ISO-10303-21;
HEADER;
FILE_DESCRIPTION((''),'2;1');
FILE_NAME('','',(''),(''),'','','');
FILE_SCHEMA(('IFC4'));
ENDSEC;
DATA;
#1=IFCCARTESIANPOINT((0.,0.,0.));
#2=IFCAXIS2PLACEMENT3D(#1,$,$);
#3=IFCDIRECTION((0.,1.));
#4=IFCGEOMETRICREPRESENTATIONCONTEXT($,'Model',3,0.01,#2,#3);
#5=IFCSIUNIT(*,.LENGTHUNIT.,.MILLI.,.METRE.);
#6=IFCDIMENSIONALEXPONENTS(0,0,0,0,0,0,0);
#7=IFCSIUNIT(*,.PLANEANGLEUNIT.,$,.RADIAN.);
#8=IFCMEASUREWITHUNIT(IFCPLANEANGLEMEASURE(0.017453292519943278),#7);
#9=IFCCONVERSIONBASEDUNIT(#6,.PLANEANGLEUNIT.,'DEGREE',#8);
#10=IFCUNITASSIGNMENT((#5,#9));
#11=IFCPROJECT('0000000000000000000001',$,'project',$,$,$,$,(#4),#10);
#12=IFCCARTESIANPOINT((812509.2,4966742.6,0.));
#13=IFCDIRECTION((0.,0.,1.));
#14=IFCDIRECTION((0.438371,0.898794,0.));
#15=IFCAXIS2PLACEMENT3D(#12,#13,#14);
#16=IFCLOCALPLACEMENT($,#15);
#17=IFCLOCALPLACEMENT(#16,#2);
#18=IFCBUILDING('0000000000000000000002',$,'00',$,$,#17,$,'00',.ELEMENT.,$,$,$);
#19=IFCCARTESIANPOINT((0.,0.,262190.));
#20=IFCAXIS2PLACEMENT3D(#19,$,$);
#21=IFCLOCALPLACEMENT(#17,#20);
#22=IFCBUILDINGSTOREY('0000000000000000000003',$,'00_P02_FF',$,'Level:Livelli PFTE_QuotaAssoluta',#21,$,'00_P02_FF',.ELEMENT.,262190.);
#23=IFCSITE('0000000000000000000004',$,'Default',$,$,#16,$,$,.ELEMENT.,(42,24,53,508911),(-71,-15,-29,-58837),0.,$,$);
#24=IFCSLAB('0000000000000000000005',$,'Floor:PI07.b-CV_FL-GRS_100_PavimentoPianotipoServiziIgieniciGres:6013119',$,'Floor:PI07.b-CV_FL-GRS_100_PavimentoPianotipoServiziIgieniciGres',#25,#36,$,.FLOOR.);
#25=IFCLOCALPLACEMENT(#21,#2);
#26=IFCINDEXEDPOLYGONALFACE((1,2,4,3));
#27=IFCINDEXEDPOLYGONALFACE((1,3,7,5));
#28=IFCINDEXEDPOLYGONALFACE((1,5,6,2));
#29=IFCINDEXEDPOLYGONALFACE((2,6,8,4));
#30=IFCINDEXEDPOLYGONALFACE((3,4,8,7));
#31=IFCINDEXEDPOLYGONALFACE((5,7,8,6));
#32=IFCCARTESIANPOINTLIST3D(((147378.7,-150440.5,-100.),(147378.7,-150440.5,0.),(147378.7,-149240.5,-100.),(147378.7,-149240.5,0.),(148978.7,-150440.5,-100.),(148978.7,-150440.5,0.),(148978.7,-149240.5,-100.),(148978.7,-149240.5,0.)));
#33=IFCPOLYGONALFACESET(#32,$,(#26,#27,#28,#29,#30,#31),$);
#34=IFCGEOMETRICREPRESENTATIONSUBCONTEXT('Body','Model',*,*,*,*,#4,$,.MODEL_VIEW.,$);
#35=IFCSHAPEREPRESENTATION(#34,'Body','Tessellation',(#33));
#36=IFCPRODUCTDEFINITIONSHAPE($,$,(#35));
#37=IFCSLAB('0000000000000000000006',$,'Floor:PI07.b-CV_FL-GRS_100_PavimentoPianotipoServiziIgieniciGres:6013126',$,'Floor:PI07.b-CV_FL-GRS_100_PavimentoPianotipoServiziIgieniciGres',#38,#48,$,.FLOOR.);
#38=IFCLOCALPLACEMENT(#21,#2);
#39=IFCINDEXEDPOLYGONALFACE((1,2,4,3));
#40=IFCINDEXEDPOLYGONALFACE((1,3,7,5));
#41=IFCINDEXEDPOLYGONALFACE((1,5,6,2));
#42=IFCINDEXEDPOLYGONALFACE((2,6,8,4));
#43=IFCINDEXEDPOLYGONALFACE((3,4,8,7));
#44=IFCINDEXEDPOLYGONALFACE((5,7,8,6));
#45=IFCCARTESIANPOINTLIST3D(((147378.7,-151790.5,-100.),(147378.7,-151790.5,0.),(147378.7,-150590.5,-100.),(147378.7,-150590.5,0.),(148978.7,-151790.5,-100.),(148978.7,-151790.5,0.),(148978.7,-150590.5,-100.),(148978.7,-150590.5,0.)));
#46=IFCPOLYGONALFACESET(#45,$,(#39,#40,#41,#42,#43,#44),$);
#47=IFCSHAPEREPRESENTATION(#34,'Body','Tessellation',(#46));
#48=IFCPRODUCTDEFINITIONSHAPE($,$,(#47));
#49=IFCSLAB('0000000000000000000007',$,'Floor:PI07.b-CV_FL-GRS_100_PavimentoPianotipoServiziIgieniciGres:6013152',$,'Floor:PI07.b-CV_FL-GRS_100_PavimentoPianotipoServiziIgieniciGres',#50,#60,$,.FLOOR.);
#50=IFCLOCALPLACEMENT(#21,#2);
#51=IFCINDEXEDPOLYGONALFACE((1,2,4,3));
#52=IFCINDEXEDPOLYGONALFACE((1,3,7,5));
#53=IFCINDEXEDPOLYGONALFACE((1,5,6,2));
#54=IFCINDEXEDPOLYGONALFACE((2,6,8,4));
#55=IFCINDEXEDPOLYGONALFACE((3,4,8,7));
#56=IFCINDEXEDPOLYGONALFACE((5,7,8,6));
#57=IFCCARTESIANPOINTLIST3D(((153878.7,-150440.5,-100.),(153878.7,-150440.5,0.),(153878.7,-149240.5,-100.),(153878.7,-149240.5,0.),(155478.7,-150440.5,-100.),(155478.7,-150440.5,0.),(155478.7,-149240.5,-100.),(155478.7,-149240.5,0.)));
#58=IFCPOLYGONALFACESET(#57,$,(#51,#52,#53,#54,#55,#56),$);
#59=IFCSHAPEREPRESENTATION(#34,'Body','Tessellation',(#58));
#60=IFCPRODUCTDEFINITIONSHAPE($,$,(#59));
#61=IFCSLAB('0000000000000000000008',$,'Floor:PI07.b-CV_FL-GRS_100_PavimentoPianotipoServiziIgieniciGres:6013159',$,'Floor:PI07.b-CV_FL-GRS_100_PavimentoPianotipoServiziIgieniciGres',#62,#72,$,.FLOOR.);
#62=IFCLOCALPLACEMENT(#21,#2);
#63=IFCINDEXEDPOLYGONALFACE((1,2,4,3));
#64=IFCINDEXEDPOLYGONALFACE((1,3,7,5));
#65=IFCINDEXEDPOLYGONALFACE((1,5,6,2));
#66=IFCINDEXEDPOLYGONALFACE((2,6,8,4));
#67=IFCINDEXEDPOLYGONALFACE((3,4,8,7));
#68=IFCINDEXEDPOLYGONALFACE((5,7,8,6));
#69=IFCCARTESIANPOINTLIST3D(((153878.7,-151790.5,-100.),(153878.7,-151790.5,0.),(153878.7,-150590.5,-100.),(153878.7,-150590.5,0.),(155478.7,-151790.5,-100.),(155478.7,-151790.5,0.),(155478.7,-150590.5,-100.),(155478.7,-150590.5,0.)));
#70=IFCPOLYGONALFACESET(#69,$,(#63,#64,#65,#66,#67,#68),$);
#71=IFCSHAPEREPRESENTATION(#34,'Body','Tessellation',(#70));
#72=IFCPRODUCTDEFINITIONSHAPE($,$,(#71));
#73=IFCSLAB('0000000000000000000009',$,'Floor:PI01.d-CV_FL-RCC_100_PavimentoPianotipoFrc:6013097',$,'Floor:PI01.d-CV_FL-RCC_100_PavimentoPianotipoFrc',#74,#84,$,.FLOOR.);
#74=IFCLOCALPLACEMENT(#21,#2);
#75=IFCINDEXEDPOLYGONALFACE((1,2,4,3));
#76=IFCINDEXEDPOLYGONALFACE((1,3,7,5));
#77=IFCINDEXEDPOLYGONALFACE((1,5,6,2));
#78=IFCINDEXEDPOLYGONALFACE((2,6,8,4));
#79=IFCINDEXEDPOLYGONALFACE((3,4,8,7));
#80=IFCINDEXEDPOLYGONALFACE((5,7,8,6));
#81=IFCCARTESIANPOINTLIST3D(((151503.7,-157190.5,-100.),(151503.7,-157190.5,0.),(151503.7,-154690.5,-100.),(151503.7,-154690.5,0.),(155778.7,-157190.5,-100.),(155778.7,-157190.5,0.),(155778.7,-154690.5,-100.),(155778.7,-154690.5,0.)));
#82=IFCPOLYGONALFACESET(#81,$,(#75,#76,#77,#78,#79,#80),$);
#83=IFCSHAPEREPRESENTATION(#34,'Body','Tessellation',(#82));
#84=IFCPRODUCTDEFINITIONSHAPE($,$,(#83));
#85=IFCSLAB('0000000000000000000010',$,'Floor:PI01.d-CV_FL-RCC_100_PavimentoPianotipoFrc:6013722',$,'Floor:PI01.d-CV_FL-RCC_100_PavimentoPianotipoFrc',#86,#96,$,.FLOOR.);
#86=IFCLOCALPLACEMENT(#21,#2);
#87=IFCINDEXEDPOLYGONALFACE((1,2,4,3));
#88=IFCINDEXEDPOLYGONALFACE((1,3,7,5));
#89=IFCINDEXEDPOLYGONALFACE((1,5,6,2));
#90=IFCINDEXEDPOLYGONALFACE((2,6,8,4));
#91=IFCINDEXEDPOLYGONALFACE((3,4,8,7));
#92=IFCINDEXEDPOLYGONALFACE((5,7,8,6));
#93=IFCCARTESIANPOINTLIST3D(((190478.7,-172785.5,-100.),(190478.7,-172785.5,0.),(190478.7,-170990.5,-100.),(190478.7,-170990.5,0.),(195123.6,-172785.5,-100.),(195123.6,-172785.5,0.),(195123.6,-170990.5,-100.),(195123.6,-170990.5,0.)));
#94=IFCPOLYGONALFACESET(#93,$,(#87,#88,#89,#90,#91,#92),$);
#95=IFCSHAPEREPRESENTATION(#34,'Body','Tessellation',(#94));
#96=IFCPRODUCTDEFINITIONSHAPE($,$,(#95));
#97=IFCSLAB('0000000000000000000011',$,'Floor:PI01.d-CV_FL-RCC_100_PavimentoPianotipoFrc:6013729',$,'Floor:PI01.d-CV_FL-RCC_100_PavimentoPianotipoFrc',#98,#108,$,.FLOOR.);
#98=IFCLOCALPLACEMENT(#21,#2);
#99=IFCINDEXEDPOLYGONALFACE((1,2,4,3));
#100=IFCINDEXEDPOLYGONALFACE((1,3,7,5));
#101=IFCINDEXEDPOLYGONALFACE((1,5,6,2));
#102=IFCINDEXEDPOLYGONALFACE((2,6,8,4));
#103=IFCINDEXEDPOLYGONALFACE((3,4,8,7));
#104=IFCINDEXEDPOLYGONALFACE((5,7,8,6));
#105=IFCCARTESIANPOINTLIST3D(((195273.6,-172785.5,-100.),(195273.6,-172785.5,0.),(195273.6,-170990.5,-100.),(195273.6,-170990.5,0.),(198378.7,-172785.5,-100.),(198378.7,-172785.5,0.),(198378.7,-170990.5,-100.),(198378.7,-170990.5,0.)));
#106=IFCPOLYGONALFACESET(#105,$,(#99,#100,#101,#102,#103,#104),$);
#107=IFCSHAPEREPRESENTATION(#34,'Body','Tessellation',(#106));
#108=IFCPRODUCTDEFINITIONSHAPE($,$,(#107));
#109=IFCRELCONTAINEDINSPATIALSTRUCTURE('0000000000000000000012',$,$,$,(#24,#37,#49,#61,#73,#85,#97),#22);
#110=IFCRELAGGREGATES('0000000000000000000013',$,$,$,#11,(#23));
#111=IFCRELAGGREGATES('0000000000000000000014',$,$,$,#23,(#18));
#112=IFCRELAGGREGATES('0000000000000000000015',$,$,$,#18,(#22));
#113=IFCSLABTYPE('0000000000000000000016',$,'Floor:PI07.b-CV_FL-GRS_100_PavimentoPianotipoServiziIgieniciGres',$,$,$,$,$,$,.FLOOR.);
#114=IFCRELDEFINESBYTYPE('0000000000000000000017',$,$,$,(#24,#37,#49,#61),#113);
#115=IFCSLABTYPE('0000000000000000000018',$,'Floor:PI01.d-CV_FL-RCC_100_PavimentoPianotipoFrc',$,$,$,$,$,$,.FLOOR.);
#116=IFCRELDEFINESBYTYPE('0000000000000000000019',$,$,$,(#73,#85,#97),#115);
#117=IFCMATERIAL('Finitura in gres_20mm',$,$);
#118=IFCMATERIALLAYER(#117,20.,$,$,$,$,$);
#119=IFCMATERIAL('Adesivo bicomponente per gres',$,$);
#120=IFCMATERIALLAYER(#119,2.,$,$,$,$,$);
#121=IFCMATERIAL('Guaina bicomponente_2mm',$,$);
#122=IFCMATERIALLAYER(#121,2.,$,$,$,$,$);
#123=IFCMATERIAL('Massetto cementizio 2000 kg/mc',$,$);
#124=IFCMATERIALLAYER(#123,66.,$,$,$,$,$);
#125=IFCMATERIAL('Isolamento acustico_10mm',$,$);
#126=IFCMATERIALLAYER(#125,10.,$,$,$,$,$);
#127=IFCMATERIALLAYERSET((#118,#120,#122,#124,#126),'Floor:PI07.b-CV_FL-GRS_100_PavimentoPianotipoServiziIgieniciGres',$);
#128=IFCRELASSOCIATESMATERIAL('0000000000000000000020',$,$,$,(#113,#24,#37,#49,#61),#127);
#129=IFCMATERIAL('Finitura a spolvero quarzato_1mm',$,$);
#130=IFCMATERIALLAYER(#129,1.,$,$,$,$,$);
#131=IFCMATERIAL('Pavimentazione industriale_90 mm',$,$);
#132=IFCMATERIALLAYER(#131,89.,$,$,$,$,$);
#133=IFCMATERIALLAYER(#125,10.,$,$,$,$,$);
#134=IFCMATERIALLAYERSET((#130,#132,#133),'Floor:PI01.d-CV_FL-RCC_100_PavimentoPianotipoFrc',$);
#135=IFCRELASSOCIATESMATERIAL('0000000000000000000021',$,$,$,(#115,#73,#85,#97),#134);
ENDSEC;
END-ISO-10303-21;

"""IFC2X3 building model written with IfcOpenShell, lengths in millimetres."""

from ifc_helpers import new_model, entity, si_unit, converted_unit, direction, frame, frame_2d, origin, place, context, subcontext, project, spatial, rectangle, extrude, material, layer, layer_set, layer_usage, type_object, element, save


model = new_model("IFC2X3")

# Units and contexts
model_context = context("Model", 3, precision=0.01, world=origin(), true_north=direction((0.0, 1.0)))
body_context = subcontext(model_context, "Body", "Model", "MODEL_VIEW")
ifc_project = project(units=[si_unit("LENGTHUNIT", "METRE", prefix="MILLI"), converted_unit("PLANEANGLEUNIT", "DEGREE", entity("IfcPlaneAngleMeasure", 0.017453292519943278), si_unit("PLANEANGLEUNIT", "RADIAN"), dimensions=[0, 0, 0, 0, 0, 0, 0])], contexts=[model_context])

# Site, building, storey
site_placement = place(None, frame((812509.2, 4966742.6, 0.0), z_axis=(0.0, 0.0, 1.0), x_axis=(0.438371, 0.898794, 0.0)))
site = spatial("IfcSite", under=ifc_project, at=site_placement, Name="Default", CompositionType="ELEMENT", RefLatitude=(42, 24, 53, 508911), RefLongitude=(-71, -15, -29, -58837), RefElevation=0.0)
building_placement = place(site_placement, origin())
building = spatial("IfcBuilding", under=site, at=building_placement, Name="00", LongName="00", CompositionType="ELEMENT")
storey_placement = place(building_placement, frame((0.0, 0.0, 262190.0)))
storey = spatial("IfcBuildingStorey", under=building, at=storey_placement, Name="00_P02_FF", ObjectType="Level:Livelli PFTE_QuotaAssoluta", LongName="00_P02_FF", CompositionType="ELEMENT", Elevation=262190.0)

# Slabs
ifc_material_1 = material(Name="Massetto cementizio 2000 kg/mc")
ifc_material_2 = material(Name="Isolamento acustico_10mm")
ifc_material_3 = material(Name="Finitura in gres_20mm")
ifc_layer_1 = layer(ifc_material_3, 20.0)
ifc_material_4 = material(Name="Adesivo bicomponente per gres")
ifc_layer_2 = layer(ifc_material_4, 2.0)
ifc_material_5 = material(Name="Guaina bicomponente_2mm")
ifc_layer_3 = layer(ifc_material_5, 2.0)
ifc_layer_4 = layer(ifc_material_1, 66.0)
ifc_layer_5 = layer(ifc_material_2, 10.0)
ifc_layer_set_1 = layer_set([ifc_layer_1, ifc_layer_2, ifc_layer_3, ifc_layer_4, ifc_layer_5], Name="Floor:PI07.b-CV_FL-GRS_100_PavimentoPianotipoServiziIgieniciGres")
ifc_layer_usage_1 = layer_usage(ifc_layer_set_1, "AXIS3", "POSITIVE", 0.0)
slab_type_1 = type_object("IfcSlabType", Name="Floor:PI07.b-CV_FL-GRS_100_PavimentoPianotipoServiziIgieniciGres", PredefinedType="FLOOR", material=ifc_layer_set_1)
slab_1_placement = place(storey_placement, origin())
element("IfcSlab", 1, at=slab_1_placement, inside=storey, type_object=slab_type_1, material=ifc_layer_usage_1, Name="Floor:PI07.b-CV_FL-GRS_100_PavimentoPianotipoServiziIgieniciGres:6013119", ObjectType="Floor:PI07.b-CV_FL-GRS_100_PavimentoPianotipoServiziIgieniciGres", PredefinedType="FLOOR", context=body_context, shape_type="SweptSolid", body=[
    extrude(rectangle(XDim=1200.0, YDim=1600.0, at=frame_2d((0.0, 0.0), x_axis=(1.0, 0.0))), frame((148178.7, -149840.5, 0.0), z_axis=(0.0, 0.0, -1.0), x_axis=(0.0, 1.0, 0.0)), (0.0, 0.0, 1.0), 100.0),
])
ifc_layer_usage_2 = layer_usage(ifc_layer_set_1, "AXIS3", "POSITIVE", 0.0)
slab_2_placement = place(storey_placement, origin())
element("IfcSlab", 2, at=slab_2_placement, inside=storey, type_object=slab_type_1, material=ifc_layer_usage_2, Name="Floor:PI07.b-CV_FL-GRS_100_PavimentoPianotipoServiziIgieniciGres:6013126", ObjectType="Floor:PI07.b-CV_FL-GRS_100_PavimentoPianotipoServiziIgieniciGres", PredefinedType="FLOOR", context=body_context, shape_type="SweptSolid", body=[
    extrude(rectangle(XDim=1200.0, YDim=1600.0, at=frame_2d((0.0, 0.0), x_axis=(1.0, 0.0))), frame((148178.7, -151190.5, 0.0), z_axis=(0.0, 0.0, -1.0), x_axis=(0.0, 1.0, 0.0)), (0.0, 0.0, 1.0), 100.0),
])
ifc_layer_usage_3 = layer_usage(ifc_layer_set_1, "AXIS3", "POSITIVE", 0.0)
slab_3_placement = place(storey_placement, origin())
element("IfcSlab", 3, at=slab_3_placement, inside=storey, type_object=slab_type_1, material=ifc_layer_usage_3, Name="Floor:PI07.b-CV_FL-GRS_100_PavimentoPianotipoServiziIgieniciGres:6013152", ObjectType="Floor:PI07.b-CV_FL-GRS_100_PavimentoPianotipoServiziIgieniciGres", PredefinedType="FLOOR", context=body_context, shape_type="SweptSolid", body=[
    extrude(rectangle(XDim=1200.0, YDim=1600.0, at=frame_2d((0.0, 0.0), x_axis=(1.0, 0.0))), frame((154678.7, -149840.5, 0.0), z_axis=(0.0, 0.0, -1.0), x_axis=(0.0, 1.0, 0.0)), (0.0, 0.0, 1.0), 100.0),
])
ifc_layer_usage_4 = layer_usage(ifc_layer_set_1, "AXIS3", "POSITIVE", 0.0)
slab_4_placement = place(storey_placement, origin())
element("IfcSlab", 4, at=slab_4_placement, inside=storey, type_object=slab_type_1, material=ifc_layer_usage_4, Name="Floor:PI07.b-CV_FL-GRS_100_PavimentoPianotipoServiziIgieniciGres:6013159", ObjectType="Floor:PI07.b-CV_FL-GRS_100_PavimentoPianotipoServiziIgieniciGres", PredefinedType="FLOOR", context=body_context, shape_type="SweptSolid", body=[
    extrude(rectangle(XDim=1200.0, YDim=1600.0, at=frame_2d((0.0, 0.0), x_axis=(1.0, 0.0))), frame((154678.7, -151190.5, 0.0), z_axis=(0.0, 0.0, -1.0), x_axis=(0.0, 1.0, 0.0)), (0.0, 0.0, 1.0), 100.0),
])
ifc_material_6 = material(Name="Finitura a spolvero quarzato_1mm")
ifc_layer_6 = layer(ifc_material_6, 1.0)
ifc_material_7 = material(Name="Pavimentazione industriale_90 mm")
ifc_layer_7 = layer(ifc_material_7, 89.0)
ifc_layer_8 = layer(ifc_material_2, 10.0)
ifc_layer_set_2 = layer_set([ifc_layer_6, ifc_layer_7, ifc_layer_8], Name="Floor:PI01.d-CV_FL-RCC_100_PavimentoPianotipoFrc")
slab_type_2 = type_object("IfcSlabType", Name="Floor:PI01.d-CV_FL-RCC_100_PavimentoPianotipoFrc", PredefinedType="FLOOR", material=ifc_layer_set_2)
ifc_layer_usage_5 = layer_usage(ifc_layer_set_2, "AXIS3", "POSITIVE", 0.0)
slab_5_placement = place(storey_placement, origin())
element("IfcSlab", 5, at=slab_5_placement, inside=storey, type_object=slab_type_2, material=ifc_layer_usage_5, Name="Floor:PI01.d-CV_FL-RCC_100_PavimentoPianotipoFrc:6013097", ObjectType="Floor:PI01.d-CV_FL-RCC_100_PavimentoPianotipoFrc", PredefinedType="FLOOR", context=body_context, shape_type="SweptSolid", body=[
    extrude(rectangle(XDim=2500.0, YDim=4275.0, at=frame_2d((0.0, 0.0), x_axis=(1.0, 0.0))), frame((153641.2, -155940.5, 0.0), z_axis=(0.0, 0.0, -1.0), x_axis=(0.0, 1.0, 0.0)), (0.0, 0.0, 1.0), 100.0),
])
ifc_layer_usage_6 = layer_usage(ifc_layer_set_2, "AXIS3", "POSITIVE", 0.0)
slab_6_placement = place(storey_placement, origin())
element("IfcSlab", 6, at=slab_6_placement, inside=storey, type_object=slab_type_2, material=ifc_layer_usage_6, Name="Floor:PI01.d-CV_FL-RCC_100_PavimentoPianotipoFrc:6013722", ObjectType="Floor:PI01.d-CV_FL-RCC_100_PavimentoPianotipoFrc", PredefinedType="FLOOR", context=body_context, shape_type="SweptSolid", body=[
    extrude(rectangle(XDim=1795.0, YDim=4645.0, at=frame_2d((0.0, 0.0), x_axis=(1.0, 0.0))), frame((192801.2, -171888.0, 0.0), z_axis=(0.0, 0.0, -1.0), x_axis=(0.0, 1.0, 0.0)), (0.0, 0.0, 1.0), 100.0),
])
ifc_layer_usage_7 = layer_usage(ifc_layer_set_2, "AXIS3", "POSITIVE", 0.0)
slab_7_placement = place(storey_placement, origin())
element("IfcSlab", 7, at=slab_7_placement, inside=storey, type_object=slab_type_2, material=ifc_layer_usage_7, Name="Floor:PI01.d-CV_FL-RCC_100_PavimentoPianotipoFrc:6013729", ObjectType="Floor:PI01.d-CV_FL-RCC_100_PavimentoPianotipoFrc", PredefinedType="FLOOR", context=body_context, shape_type="SweptSolid", body=[
    extrude(rectangle(XDim=1795.0, YDim=3105.0, at=frame_2d((0.0, 0.0), x_axis=(1.0, 0.0))), frame((196826.2, -171888.0, 0.0), z_axis=(0.0, 0.0, -1.0), x_axis=(0.0, 1.0, 0.0)), (0.0, 0.0, 1.0), 100.0),
])

save(model, "model.ifc")
